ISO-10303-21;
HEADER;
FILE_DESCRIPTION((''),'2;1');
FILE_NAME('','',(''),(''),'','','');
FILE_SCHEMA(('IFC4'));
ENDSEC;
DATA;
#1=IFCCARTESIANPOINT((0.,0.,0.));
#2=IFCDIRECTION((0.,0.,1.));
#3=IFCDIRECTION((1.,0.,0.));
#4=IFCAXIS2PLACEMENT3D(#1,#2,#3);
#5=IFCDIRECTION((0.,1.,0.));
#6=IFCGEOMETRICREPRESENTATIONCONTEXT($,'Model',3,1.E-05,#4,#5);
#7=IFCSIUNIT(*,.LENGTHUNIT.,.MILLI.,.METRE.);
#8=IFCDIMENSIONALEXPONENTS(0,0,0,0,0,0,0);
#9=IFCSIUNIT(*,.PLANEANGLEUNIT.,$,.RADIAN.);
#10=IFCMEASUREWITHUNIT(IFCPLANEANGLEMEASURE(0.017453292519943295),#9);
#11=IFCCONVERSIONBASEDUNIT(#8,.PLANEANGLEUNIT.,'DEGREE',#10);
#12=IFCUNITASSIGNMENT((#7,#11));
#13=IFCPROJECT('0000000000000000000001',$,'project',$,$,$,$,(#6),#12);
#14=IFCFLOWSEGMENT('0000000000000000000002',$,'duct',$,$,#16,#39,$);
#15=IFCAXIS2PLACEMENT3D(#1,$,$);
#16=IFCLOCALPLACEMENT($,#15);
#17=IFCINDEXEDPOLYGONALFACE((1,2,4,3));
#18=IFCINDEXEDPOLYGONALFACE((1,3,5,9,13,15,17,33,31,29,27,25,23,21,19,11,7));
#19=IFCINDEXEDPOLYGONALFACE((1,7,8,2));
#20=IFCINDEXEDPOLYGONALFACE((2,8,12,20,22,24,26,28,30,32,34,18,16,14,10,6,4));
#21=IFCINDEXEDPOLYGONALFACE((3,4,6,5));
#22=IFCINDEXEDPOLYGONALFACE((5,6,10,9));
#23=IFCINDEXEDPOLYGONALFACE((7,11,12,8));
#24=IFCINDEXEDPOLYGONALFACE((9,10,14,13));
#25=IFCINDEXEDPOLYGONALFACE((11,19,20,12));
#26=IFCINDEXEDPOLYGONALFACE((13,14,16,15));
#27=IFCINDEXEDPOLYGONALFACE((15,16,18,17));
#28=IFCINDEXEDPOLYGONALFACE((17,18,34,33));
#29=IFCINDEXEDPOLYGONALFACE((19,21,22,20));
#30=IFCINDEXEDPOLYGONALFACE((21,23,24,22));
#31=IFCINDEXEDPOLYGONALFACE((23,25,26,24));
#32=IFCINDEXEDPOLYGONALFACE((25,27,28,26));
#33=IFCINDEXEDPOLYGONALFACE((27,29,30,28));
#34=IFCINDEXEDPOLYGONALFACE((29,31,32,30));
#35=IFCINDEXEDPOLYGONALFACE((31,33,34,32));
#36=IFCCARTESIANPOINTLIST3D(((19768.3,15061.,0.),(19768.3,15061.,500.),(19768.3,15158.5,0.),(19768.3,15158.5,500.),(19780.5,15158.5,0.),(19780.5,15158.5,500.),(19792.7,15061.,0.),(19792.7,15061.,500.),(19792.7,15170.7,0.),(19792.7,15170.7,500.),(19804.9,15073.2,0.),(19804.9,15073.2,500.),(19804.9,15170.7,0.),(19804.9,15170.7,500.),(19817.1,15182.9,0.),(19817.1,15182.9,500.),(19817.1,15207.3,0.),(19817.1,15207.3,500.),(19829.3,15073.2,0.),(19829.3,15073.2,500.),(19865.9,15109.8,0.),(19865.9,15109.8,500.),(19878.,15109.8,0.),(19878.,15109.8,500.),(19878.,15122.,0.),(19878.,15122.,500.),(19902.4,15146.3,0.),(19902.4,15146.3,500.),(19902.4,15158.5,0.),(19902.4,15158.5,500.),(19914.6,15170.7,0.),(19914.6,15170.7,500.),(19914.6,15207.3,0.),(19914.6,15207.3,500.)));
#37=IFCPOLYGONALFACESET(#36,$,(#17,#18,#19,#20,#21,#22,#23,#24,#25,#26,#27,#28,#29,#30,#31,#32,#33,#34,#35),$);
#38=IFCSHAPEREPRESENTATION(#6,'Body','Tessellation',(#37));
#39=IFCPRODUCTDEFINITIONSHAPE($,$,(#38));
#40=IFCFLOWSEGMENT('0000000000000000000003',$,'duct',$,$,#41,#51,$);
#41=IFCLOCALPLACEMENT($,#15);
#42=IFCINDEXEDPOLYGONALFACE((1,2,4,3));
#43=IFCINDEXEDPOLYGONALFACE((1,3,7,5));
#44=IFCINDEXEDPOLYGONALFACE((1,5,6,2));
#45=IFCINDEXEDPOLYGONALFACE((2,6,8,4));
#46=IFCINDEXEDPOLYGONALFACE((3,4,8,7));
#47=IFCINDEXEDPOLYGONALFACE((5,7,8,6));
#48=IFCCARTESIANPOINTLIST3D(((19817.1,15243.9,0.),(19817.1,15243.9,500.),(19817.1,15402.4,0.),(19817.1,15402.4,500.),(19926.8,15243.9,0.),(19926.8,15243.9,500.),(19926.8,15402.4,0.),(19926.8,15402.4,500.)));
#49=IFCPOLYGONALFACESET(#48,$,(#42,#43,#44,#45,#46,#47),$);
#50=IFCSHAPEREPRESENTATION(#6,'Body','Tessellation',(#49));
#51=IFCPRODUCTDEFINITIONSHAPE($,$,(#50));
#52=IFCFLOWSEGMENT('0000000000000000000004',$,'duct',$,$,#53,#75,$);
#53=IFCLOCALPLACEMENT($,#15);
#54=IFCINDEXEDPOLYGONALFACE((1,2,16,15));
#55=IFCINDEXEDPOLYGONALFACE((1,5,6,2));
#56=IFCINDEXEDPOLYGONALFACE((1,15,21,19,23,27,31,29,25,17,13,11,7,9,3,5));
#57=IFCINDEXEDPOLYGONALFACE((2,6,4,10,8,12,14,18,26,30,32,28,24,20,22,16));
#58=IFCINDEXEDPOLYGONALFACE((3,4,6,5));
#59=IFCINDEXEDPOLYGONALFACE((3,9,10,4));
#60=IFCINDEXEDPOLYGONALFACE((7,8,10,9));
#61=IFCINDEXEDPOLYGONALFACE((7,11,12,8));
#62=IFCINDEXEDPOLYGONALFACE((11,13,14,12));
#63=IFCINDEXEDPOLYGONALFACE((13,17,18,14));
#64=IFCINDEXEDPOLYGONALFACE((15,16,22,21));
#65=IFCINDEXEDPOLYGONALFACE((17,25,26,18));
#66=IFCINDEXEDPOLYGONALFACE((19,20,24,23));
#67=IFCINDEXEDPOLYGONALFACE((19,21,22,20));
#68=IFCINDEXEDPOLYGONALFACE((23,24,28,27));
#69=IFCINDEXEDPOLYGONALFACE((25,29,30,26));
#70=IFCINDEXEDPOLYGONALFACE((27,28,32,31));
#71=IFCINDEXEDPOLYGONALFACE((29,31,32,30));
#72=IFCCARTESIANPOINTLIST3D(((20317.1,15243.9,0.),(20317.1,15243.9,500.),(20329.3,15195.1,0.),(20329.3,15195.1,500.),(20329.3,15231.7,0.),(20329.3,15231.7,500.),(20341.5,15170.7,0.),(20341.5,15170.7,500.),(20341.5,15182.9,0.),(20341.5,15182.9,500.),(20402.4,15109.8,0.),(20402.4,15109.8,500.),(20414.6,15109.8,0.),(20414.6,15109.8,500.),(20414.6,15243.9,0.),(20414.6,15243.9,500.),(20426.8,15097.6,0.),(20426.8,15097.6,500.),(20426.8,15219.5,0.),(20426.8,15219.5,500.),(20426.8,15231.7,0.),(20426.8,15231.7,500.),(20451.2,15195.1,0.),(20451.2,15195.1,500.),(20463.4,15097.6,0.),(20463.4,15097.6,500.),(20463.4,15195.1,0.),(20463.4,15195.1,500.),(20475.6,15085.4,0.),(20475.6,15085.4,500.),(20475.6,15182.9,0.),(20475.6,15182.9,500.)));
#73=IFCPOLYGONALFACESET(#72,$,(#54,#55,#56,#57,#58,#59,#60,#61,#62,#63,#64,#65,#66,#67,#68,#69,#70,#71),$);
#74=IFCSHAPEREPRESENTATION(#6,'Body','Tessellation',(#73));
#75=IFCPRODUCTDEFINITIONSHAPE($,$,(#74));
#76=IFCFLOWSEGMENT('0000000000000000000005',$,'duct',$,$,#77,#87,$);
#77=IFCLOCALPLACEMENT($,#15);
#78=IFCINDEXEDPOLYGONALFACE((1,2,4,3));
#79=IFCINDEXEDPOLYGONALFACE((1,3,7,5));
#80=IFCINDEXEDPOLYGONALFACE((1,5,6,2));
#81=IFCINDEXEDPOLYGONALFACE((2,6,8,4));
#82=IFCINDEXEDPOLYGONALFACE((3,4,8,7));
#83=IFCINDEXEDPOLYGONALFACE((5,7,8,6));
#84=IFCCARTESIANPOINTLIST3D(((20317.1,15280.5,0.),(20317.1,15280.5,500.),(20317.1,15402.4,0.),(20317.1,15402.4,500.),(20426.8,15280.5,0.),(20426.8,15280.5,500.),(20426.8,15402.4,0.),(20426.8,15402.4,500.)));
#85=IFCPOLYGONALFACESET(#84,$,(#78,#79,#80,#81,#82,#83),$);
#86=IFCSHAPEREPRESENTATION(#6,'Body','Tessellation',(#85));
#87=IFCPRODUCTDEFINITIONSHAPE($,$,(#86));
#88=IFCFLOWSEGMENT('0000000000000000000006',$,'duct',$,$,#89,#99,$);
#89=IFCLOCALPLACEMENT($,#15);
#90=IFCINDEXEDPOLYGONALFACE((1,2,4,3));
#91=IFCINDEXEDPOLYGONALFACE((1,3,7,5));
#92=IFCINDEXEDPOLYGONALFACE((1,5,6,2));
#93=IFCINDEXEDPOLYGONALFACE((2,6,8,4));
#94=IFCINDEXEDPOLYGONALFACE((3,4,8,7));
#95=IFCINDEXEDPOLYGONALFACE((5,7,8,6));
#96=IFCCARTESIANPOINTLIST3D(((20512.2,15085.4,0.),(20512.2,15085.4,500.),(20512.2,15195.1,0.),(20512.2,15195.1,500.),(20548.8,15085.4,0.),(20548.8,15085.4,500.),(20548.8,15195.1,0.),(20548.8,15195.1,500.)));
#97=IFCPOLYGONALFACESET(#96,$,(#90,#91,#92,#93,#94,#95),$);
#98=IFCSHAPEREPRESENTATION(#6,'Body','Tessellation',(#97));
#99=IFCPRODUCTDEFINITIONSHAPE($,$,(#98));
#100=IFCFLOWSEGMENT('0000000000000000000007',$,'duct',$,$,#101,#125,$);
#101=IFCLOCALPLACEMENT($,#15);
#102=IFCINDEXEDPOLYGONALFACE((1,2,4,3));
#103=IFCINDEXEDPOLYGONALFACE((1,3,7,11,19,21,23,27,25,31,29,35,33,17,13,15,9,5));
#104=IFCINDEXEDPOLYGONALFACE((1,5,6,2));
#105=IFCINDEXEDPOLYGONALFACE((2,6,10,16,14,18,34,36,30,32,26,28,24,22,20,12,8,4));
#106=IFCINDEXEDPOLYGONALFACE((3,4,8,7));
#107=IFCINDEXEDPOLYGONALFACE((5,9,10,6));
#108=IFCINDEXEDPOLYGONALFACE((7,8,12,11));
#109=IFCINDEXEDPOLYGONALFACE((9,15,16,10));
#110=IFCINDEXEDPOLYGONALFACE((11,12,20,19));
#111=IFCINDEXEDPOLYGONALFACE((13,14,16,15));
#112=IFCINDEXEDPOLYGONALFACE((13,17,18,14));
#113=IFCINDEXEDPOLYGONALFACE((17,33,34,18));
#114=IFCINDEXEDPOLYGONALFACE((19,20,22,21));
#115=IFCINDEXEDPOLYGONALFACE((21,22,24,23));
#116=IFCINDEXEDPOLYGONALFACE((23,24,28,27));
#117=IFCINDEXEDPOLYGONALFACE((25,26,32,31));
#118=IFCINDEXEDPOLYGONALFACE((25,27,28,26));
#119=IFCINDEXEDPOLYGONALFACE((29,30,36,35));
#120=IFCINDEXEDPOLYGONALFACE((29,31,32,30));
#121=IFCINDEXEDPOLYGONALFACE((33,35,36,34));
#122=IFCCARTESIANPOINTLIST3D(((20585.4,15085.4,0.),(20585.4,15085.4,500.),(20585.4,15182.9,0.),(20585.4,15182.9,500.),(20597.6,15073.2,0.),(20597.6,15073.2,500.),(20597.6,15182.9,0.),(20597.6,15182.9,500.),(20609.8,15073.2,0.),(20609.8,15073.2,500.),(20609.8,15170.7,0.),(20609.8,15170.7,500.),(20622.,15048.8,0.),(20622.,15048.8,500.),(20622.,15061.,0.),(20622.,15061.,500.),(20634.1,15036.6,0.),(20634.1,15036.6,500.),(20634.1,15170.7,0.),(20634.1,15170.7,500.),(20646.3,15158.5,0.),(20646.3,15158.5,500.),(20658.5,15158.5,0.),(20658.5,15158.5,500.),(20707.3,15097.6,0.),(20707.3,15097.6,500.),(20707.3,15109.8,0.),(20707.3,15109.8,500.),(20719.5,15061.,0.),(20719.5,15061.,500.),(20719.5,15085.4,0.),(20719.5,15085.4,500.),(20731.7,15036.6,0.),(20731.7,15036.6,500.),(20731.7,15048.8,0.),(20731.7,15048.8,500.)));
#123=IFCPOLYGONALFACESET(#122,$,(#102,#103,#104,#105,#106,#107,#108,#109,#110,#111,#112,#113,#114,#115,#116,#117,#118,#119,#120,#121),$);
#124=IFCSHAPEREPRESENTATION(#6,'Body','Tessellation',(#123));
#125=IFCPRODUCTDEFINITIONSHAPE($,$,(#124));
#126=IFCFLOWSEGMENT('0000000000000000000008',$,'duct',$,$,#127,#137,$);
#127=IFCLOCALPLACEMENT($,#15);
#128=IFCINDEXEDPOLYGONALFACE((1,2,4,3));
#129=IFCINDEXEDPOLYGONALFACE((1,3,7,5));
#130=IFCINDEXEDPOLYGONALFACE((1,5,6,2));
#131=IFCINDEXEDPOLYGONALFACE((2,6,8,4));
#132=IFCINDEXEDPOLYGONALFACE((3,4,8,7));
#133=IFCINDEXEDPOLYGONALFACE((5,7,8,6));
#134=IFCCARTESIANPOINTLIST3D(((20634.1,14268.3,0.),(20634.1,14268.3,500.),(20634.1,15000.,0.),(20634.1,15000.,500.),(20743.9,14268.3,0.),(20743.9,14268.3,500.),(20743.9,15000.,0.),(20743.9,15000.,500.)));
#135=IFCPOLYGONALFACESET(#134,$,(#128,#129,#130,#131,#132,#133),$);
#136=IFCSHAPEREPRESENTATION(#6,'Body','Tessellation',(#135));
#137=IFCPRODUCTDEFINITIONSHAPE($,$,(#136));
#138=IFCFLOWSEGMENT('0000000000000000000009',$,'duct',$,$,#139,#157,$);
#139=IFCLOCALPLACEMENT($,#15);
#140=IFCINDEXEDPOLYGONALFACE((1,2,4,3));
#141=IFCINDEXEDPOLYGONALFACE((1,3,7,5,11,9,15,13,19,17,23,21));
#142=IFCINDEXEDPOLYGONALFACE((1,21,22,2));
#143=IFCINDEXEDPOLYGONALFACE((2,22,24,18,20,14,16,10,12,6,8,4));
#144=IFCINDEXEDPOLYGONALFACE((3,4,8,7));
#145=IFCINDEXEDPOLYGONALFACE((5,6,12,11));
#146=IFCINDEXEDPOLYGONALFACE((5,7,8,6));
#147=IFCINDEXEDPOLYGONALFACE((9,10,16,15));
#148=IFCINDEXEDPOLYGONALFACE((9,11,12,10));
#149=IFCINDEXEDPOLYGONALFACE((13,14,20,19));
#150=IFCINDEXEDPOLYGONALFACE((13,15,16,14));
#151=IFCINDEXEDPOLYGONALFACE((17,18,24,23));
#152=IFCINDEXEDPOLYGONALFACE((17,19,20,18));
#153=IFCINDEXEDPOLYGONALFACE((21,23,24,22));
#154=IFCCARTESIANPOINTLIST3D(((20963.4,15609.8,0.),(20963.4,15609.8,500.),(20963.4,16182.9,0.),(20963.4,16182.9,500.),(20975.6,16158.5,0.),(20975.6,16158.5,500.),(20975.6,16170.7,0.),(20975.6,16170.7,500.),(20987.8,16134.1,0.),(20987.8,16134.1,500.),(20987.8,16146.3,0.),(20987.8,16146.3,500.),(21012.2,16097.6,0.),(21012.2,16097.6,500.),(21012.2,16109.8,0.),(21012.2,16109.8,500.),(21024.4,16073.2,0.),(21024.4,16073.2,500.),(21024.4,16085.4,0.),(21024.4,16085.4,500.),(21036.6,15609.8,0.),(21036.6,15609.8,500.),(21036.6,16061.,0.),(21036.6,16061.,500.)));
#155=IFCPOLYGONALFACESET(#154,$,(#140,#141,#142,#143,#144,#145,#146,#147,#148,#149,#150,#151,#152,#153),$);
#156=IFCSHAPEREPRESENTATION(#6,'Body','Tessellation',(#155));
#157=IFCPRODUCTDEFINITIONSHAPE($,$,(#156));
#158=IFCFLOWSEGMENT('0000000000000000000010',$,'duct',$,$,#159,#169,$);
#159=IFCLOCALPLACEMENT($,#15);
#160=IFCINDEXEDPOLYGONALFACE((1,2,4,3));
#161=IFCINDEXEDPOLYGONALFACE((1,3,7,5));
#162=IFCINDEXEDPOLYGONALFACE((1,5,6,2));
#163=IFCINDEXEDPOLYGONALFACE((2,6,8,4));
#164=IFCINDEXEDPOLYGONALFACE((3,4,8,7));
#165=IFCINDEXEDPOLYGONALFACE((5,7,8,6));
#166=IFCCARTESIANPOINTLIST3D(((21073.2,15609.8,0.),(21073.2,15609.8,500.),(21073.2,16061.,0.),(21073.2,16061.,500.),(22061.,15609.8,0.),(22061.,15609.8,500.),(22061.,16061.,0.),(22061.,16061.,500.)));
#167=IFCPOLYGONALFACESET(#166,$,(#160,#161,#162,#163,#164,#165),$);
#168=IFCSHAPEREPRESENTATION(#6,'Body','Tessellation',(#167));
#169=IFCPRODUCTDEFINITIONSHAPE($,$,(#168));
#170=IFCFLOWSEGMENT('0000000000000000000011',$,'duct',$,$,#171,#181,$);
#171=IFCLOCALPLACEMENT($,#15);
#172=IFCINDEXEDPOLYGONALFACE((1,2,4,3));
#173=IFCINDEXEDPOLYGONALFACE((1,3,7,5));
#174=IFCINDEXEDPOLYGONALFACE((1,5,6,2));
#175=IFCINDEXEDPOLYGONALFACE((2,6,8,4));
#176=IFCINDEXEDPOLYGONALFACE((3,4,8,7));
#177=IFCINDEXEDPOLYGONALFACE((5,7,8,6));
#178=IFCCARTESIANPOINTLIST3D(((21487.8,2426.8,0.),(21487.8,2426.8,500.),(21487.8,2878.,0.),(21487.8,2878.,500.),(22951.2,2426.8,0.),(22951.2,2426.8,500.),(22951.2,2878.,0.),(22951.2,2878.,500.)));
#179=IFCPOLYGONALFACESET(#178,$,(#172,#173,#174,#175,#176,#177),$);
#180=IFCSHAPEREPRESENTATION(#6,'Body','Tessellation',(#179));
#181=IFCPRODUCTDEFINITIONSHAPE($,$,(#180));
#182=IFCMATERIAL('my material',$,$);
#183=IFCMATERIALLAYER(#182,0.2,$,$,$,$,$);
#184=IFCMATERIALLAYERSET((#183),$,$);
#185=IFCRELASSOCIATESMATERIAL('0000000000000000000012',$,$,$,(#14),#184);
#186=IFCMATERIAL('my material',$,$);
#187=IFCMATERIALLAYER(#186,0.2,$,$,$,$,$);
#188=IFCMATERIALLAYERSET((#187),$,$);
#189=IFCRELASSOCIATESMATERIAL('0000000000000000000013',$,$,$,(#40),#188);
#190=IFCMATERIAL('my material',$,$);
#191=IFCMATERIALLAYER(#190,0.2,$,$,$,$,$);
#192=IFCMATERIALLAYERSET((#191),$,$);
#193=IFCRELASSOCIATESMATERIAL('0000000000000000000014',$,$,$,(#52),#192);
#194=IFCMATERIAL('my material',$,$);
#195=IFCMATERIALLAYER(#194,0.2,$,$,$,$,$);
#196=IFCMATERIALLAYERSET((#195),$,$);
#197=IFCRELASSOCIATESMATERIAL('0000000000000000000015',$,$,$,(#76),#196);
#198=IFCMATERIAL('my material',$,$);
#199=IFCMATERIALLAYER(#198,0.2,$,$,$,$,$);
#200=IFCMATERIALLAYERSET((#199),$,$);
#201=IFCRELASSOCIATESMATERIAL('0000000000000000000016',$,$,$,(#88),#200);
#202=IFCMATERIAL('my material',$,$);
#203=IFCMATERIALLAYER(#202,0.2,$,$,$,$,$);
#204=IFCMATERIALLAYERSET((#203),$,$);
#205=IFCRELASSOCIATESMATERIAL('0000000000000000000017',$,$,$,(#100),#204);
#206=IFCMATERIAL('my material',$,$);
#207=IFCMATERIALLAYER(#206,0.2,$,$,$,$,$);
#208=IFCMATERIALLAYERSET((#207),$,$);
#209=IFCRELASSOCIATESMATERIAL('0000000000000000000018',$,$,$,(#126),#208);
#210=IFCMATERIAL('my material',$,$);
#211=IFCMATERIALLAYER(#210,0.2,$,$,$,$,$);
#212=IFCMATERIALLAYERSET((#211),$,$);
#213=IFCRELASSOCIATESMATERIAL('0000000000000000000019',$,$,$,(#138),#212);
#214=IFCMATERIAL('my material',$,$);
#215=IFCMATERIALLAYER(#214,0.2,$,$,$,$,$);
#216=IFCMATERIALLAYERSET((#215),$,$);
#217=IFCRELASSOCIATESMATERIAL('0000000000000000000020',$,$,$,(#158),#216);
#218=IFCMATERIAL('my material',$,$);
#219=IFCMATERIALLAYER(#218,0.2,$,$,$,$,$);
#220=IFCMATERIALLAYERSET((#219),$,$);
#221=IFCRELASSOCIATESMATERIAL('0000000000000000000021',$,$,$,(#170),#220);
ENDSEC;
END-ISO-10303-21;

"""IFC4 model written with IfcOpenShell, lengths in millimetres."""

from ifc_helpers import new_model, entity, si_unit, converted_unit, direction, origin_with_axes, place, context, project, polyline, outline, extrude, material, layer, layer_set, layer_usage, element, save


model = new_model("IFC4")

# Units and contexts
model_context = context("Model", 3, precision=1e-05, world=origin_with_axes(), true_north=direction((0.0, 1.0, 0.0)))
ifc_project = project(units=[si_unit("LENGTHUNIT", "METRE", prefix="MILLI"), converted_unit("PLANEANGLEUNIT", "DEGREE", entity("IfcPlaneAngleMeasure", 0.017453292519943295), si_unit("PLANEANGLEUNIT", "RADIAN"), dimensions=[0, 0, 0, 0, 0, 0, 0])], contexts=[model_context])

# Flow segments
ifc_material_1 = material(Name="my material")
ifc_layer_1 = layer(ifc_material_1, 0.2)
ifc_layer_set_1 = layer_set([ifc_layer_1])
ifc_layer_usage_1 = layer_usage(ifc_layer_set_1, "AXIS2", "POSITIVE", -0.1)
flow_segment_1_placement = place(None, origin_with_axes())
element("IfcFlowSegment", 1, at=flow_segment_1_placement, material=ifc_layer_usage_1, Name="duct", context=model_context, shape_type="SweptSolid", body=[
    extrude(outline(polyline([(19768.3, 15061.0), (19792.7, 15061.0), (19804.9, 15073.2), (19829.3, 15073.2), (19865.9, 15109.8), (19878.0, 15109.8), (19878.0, 15122.0), (19902.4, 15146.3), (19902.4, 15158.5), (19914.6, 15170.7), (19914.6, 15207.3), (19817.1, 15207.3), (19817.1, 15182.9), (19804.9, 15170.7), (19792.7, 15170.7), (19780.5, 15158.5), (19768.3, 15158.5), (19768.3, 15061.0)])), origin_with_axes(), (0.0, 0.0, 1.0), 500.0),
])
ifc_material_2 = material(Name="my material")
ifc_layer_2 = layer(ifc_material_2, 0.2)
ifc_layer_set_2 = layer_set([ifc_layer_2])
ifc_layer_usage_2 = layer_usage(ifc_layer_set_2, "AXIS2", "POSITIVE", -0.1)
flow_segment_2_placement = place(None, origin_with_axes())
element("IfcFlowSegment", 2, at=flow_segment_2_placement, material=ifc_layer_usage_2, Name="duct", context=model_context, shape_type="SweptSolid", body=[
    extrude(outline(polyline([(19817.1, 15243.9), (19926.8, 15243.9), (19926.8, 15402.4), (19817.1, 15402.4), (19817.1, 15243.9)])), origin_with_axes(), (0.0, 0.0, 1.0), 500.0),
])
ifc_material_3 = material(Name="my material")
ifc_layer_3 = layer(ifc_material_3, 0.2)
ifc_layer_set_3 = layer_set([ifc_layer_3])
ifc_layer_usage_3 = layer_usage(ifc_layer_set_3, "AXIS2", "POSITIVE", -0.1)
flow_segment_3_placement = place(None, origin_with_axes())
element("IfcFlowSegment", 3, at=flow_segment_3_placement, material=ifc_layer_usage_3, Name="duct", context=model_context, shape_type="SweptSolid", body=[
    extrude(outline(polyline([(20317.1, 15243.9), (20329.3, 15231.7), (20329.3, 15195.1), (20341.5, 15182.9), (20341.5, 15170.7), (20402.4, 15109.8), (20414.6, 15109.8), (20426.8, 15097.6), (20463.4, 15097.6), (20475.6, 15085.4), (20475.6, 15182.9), (20463.4, 15195.1), (20451.2, 15195.1), (20426.8, 15219.5), (20426.8, 15231.7), (20414.6, 15243.9), (20317.1, 15243.9)])), origin_with_axes(), (0.0, 0.0, 1.0), 500.0),
])
ifc_material_4 = material(Name="my material")
ifc_layer_4 = layer(ifc_material_4, 0.2)
ifc_layer_set_4 = layer_set([ifc_layer_4])
ifc_layer_usage_4 = layer_usage(ifc_layer_set_4, "AXIS2", "POSITIVE", -0.1)
flow_segment_4_placement = place(None, origin_with_axes())
element("IfcFlowSegment", 4, at=flow_segment_4_placement, material=ifc_layer_usage_4, Name="duct", context=model_context, shape_type="SweptSolid", body=[
    extrude(outline(polyline([(20317.1, 15280.5), (20426.8, 15280.5), (20426.8, 15402.4), (20317.1, 15402.4), (20317.1, 15280.5)])), origin_with_axes(), (0.0, 0.0, 1.0), 500.0),
])
ifc_material_5 = material(Name="my material")
ifc_layer_5 = layer(ifc_material_5, 0.2)
ifc_layer_set_5 = layer_set([ifc_layer_5])
ifc_layer_usage_5 = layer_usage(ifc_layer_set_5, "AXIS2", "POSITIVE", -0.1)
flow_segment_5_placement = place(None, origin_with_axes())
element("IfcFlowSegment", 5, at=flow_segment_5_placement, material=ifc_layer_usage_5, Name="duct", context=model_context, shape_type="SweptSolid", body=[
    extrude(outline(polyline([(20512.2, 15085.4), (20548.8, 15085.4), (20548.8, 15195.1), (20512.2, 15195.1), (20512.2, 15085.4)])), origin_with_axes(), (0.0, 0.0, 1.0), 500.0),
])
ifc_material_6 = material(Name="my material")
ifc_layer_6 = layer(ifc_material_6, 0.2)
ifc_layer_set_6 = layer_set([ifc_layer_6])
ifc_layer_usage_6 = layer_usage(ifc_layer_set_6, "AXIS2", "POSITIVE", -0.1)
flow_segment_6_placement = place(None, origin_with_axes())
element("IfcFlowSegment", 6, at=flow_segment_6_placement, material=ifc_layer_usage_6, Name="duct", context=model_context, shape_type="SweptSolid", body=[
    extrude(outline(polyline([(20585.4, 15085.4), (20597.6, 15073.2), (20609.8, 15073.2), (20622.0, 15061.0), (20622.0, 15048.8), (20634.1, 15036.6), (20731.7, 15036.6), (20731.7, 15048.8), (20719.5, 15061.0), (20719.5, 15085.4), (20707.3, 15097.6), (20707.3, 15109.8), (20658.5, 15158.5), (20646.3, 15158.5), (20634.1, 15170.7), (20609.8, 15170.7), (20597.6, 15182.9), (20585.4, 15182.9), (20585.4, 15085.4)])), origin_with_axes(), (0.0, 0.0, 1.0), 500.0),
])
ifc_material_7 = material(Name="my material")
ifc_layer_7 = layer(ifc_material_7, 0.2)
ifc_layer_set_7 = layer_set([ifc_layer_7])
ifc_layer_usage_7 = layer_usage(ifc_layer_set_7, "AXIS2", "POSITIVE", -0.1)
flow_segment_7_placement = place(None, origin_with_axes())
element("IfcFlowSegment", 7, at=flow_segment_7_placement, material=ifc_layer_usage_7, Name="duct", context=model_context, shape_type="SweptSolid", body=[
    extrude(outline(polyline([(20634.1, 14268.3), (20743.9, 14268.3), (20743.9, 15000.0), (20634.1, 15000.0), (20634.1, 14268.3)])), origin_with_axes(), (0.0, 0.0, 1.0), 500.0),
])
ifc_material_8 = material(Name="my material")
ifc_layer_8 = layer(ifc_material_8, 0.2)
ifc_layer_set_8 = layer_set([ifc_layer_8])
ifc_layer_usage_8 = layer_usage(ifc_layer_set_8, "AXIS2", "POSITIVE", -0.1)
flow_segment_8_placement = place(None, origin_with_axes())
element("IfcFlowSegment", 8, at=flow_segment_8_placement, material=ifc_layer_usage_8, Name="duct", context=model_context, shape_type="SweptSolid", body=[
    extrude(outline(polyline([(20963.4, 15609.8), (21036.6, 15609.8), (21036.6, 16061.0), (21024.4, 16073.2), (21024.4, 16085.4), (21012.2, 16097.6), (21012.2, 16109.8), (20987.8, 16134.1), (20987.8, 16146.3), (20975.6, 16158.5), (20975.6, 16170.7), (20963.4, 16182.9), (20963.4, 16195.1), (20963.4, 15609.8)])), origin_with_axes(), (0.0, 0.0, 1.0), 500.0),
])
ifc_material_9 = material(Name="my material")
ifc_layer_9 = layer(ifc_material_9, 0.2)
ifc_layer_set_9 = layer_set([ifc_layer_9])
ifc_layer_usage_9 = layer_usage(ifc_layer_set_9, "AXIS2", "POSITIVE", -0.1)
flow_segment_9_placement = place(None, origin_with_axes())
element("IfcFlowSegment", 9, at=flow_segment_9_placement, material=ifc_layer_usage_9, Name="duct", context=model_context, shape_type="SweptSolid", body=[
    extrude(outline(polyline([(21073.2, 15609.8), (22061.0, 15609.8), (22061.0, 16061.0), (21073.2, 16061.0), (21073.2, 15609.8)])), origin_with_axes(), (0.0, 0.0, 1.0), 500.0),
])
ifc_material_10 = material(Name="my material")
ifc_layer_10 = layer(ifc_material_10, 0.2)
ifc_layer_set_10 = layer_set([ifc_layer_10])
ifc_layer_usage_10 = layer_usage(ifc_layer_set_10, "AXIS2", "POSITIVE", -0.1)
flow_segment_10_placement = place(None, origin_with_axes())
element("IfcFlowSegment", 10, at=flow_segment_10_placement, material=ifc_layer_usage_10, Name="duct", context=model_context, shape_type="SweptSolid", body=[
    extrude(outline(polyline([(21487.8, 2426.8), (22951.2, 2426.8), (22951.2, 2878.0), (21487.8, 2878.0), (21487.8, 2426.8)])), origin_with_axes(), (0.0, 0.0, 1.0), 500.0),
])

save(model, "model.ifc")
